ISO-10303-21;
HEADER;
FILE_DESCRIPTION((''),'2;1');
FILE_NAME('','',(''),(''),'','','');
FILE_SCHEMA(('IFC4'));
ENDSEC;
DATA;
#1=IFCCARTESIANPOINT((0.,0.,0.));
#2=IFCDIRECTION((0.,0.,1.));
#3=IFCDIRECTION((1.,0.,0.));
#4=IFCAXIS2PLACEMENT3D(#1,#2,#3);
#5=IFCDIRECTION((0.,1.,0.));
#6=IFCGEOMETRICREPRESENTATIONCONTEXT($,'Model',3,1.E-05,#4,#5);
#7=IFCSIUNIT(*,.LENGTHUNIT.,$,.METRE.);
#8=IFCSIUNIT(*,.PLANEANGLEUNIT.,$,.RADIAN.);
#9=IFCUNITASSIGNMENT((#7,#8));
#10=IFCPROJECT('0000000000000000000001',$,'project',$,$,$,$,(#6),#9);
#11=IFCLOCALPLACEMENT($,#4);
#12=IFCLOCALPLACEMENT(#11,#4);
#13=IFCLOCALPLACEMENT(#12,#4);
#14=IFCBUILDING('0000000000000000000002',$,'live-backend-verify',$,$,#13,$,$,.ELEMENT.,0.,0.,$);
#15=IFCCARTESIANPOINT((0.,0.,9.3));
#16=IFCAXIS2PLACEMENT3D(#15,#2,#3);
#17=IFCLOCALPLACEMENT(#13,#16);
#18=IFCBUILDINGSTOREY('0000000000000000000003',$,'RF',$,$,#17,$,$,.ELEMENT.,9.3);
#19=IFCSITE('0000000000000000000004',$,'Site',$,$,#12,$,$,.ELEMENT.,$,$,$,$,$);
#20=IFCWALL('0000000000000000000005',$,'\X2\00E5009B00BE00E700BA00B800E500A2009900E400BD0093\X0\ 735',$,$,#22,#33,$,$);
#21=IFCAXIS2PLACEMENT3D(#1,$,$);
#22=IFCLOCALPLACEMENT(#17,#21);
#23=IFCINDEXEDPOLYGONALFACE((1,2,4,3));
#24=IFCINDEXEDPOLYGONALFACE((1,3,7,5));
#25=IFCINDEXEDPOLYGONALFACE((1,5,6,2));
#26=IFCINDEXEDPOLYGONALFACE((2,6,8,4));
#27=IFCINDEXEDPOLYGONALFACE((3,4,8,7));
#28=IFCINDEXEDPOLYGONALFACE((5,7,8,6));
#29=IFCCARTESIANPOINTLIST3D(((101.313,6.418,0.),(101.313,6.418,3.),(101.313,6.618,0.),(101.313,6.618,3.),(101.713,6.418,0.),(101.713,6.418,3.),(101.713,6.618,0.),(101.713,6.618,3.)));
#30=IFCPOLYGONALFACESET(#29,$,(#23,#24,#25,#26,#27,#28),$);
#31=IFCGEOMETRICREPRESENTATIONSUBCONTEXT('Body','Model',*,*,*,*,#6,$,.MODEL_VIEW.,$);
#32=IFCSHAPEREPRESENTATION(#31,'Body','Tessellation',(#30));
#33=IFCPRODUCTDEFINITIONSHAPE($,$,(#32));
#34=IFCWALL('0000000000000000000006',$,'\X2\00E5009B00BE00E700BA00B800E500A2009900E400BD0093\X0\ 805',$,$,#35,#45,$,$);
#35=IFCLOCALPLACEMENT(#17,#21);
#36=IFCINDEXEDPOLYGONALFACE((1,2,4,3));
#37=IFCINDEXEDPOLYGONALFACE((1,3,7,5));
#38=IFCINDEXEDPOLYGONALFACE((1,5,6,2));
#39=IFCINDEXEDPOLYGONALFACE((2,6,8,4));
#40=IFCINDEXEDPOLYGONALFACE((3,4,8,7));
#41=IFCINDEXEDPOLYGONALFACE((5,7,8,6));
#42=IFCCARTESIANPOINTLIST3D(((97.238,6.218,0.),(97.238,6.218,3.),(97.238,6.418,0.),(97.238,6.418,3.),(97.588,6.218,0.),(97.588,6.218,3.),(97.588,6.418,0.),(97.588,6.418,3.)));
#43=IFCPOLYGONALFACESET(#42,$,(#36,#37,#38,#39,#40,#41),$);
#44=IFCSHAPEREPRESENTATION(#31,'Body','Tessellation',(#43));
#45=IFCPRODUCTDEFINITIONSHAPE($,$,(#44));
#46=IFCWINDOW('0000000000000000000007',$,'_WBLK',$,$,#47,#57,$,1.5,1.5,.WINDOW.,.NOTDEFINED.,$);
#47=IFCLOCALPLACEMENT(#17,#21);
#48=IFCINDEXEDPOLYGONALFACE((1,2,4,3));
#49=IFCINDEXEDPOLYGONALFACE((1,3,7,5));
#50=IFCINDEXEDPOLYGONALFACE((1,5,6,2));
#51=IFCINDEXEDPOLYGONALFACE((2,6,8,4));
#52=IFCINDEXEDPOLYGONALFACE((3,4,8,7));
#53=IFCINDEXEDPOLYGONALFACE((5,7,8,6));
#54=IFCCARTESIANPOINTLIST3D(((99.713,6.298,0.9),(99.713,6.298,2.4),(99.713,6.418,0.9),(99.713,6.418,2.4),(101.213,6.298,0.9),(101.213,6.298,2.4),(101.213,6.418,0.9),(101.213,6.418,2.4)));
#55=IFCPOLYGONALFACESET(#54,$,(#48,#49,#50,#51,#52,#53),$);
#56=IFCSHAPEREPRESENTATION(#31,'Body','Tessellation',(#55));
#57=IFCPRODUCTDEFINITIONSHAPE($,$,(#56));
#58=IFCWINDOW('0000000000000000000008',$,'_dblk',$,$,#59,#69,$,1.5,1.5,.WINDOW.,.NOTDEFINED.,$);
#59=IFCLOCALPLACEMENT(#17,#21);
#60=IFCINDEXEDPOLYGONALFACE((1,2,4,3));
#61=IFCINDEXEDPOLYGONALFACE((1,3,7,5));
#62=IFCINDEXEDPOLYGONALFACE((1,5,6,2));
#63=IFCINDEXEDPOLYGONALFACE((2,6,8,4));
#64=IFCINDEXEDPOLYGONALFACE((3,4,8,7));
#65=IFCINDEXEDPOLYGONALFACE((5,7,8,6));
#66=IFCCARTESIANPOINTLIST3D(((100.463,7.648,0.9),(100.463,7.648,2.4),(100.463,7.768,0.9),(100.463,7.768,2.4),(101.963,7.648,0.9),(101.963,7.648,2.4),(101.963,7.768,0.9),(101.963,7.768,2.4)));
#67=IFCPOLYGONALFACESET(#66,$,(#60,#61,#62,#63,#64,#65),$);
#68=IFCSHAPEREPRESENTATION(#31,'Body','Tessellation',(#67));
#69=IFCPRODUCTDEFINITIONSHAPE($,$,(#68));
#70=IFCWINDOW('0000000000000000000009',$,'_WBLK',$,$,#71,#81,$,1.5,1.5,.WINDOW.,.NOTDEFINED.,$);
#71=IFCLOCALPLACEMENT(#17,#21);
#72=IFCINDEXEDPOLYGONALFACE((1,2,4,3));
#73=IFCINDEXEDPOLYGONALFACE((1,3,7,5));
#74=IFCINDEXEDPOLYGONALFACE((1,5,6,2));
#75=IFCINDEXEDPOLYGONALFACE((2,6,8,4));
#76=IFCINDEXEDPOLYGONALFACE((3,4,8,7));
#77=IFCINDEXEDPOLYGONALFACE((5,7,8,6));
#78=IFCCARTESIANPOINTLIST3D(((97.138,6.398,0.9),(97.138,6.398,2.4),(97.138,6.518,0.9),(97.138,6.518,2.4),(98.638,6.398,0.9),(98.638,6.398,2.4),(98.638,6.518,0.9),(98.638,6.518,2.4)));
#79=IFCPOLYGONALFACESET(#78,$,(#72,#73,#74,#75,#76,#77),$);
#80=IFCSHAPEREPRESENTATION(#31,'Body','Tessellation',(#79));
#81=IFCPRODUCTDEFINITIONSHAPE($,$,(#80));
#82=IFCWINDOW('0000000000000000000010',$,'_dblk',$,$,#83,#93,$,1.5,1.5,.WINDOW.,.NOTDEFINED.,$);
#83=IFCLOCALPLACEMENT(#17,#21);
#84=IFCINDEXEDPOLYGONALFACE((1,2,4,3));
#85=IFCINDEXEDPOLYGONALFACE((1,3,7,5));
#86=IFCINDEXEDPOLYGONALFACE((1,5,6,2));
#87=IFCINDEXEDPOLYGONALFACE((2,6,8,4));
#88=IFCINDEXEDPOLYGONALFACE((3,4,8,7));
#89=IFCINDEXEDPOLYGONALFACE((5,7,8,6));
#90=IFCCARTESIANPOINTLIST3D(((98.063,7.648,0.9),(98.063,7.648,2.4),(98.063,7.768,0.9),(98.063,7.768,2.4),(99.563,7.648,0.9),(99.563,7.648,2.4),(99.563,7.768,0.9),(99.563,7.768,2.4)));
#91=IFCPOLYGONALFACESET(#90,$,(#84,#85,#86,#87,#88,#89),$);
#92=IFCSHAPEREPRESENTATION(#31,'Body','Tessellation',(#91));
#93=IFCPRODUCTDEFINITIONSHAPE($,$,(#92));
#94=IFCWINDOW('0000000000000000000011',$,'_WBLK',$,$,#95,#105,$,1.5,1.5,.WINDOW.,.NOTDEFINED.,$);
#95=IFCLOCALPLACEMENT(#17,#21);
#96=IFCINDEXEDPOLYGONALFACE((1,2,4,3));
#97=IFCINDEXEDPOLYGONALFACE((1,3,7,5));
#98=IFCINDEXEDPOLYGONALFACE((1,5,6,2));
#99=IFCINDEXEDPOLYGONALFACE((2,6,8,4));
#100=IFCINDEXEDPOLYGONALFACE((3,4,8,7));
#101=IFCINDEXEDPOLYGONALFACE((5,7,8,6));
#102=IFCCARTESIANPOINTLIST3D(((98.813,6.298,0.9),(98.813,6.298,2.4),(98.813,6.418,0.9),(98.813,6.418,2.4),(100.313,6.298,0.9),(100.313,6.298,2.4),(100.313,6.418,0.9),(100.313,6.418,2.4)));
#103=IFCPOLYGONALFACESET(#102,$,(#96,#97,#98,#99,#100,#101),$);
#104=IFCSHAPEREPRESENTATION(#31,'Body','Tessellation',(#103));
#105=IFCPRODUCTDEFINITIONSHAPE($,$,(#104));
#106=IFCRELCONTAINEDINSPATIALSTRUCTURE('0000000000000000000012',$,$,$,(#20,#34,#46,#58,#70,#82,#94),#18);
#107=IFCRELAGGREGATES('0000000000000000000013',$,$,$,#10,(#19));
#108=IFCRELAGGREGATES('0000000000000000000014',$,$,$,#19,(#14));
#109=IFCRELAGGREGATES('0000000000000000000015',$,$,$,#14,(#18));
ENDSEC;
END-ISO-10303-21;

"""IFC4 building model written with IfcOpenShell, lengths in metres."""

from ifc_helpers import new_model, si_unit, direction, frame, frame_2d, origin_with_axes, place, context, subcontext, project, spatial, rectangle, extrude, element, save


model = new_model("IFC4")

# Units and contexts
model_context = context("Model", 3, precision=1e-05, world=origin_with_axes(), true_north=direction((0.0, 1.0, 0.0)))
body_context = subcontext(model_context, "Body", "Model", "MODEL_VIEW")
ifc_project = project(units=[si_unit("LENGTHUNIT", "METRE"), si_unit("PLANEANGLEUNIT", "RADIAN")], contexts=[model_context])

# Site, building, storey
placement = place(None, origin_with_axes())
site_placement = place(placement, origin_with_axes())
site = spatial("IfcSite", under=ifc_project, at=site_placement, Name="Site", CompositionType="ELEMENT")
building_placement = place(site_placement, origin_with_axes())
building = spatial("IfcBuilding", under=site, at=building_placement, Name="live-backend-verify", CompositionType="ELEMENT", ElevationOfRefHeight=0.0, ElevationOfTerrain=0.0)
storey_placement = place(building_placement, frame((0.0, 0.0, 9.3), z_axis=(0.0, 0.0, 1.0), x_axis=(1.0, 0.0, 0.0)))
storey = spatial("IfcBuildingStorey", under=building, at=storey_placement, Name="RF", CompositionType="ELEMENT", Elevation=9.3)

# Walls
wall_1_placement = place(storey_placement, frame((101.513, 6.518, 0.0), z_axis=(0.0, 0.0, 1.0), x_axis=(1.0, 0.0, 0.0)))
element("IfcWall", 1, at=wall_1_placement, inside=storey, Name="å\u009b¾çº¸å¢\u0099ä½\u0093 735", context=body_context, shape_type="SweptSolid", body=[
    extrude(rectangle(XDim=0.4, YDim=0.2, at=frame_2d((0.0, 0.0), x_axis=(1.0, 0.0, 0.0))), frame((0.0, 0.0, 0.0), z_axis=(0.0, 0.0, 1.0)), (0.0, 0.0, 1.0), 3.0),
])
for number, where, z_axis, x_axis, name in (
    (2, (97.413, 6.318, 0.0), (0.0, 0.0, 1.0), (1.0, 0.0, 0.0), "å\u009b¾çº¸å¢\u0099ä½\u0093 805"),
):
    element("IfcWall", number, at=place(storey_placement, frame(where, z_axis=z_axis, x_axis=x_axis)), inside=storey, Name=name, context=body_context, shape_type="SweptSolid", body=[
        extrude(rectangle(XDim=0.35, YDim=0.2, at=frame_2d((0.0, 0.0), x_axis=(1.0, 0.0, 0.0))), frame((0.0, 0.0, 0.0), z_axis=(0.0, 0.0, 1.0)), (0.0, 0.0, 1.0), 3.0),
    ])

# Windows
for number, where, z_axis, x_axis, name in (
    (3, (100.463, 6.358, 0.9), (0.0, 0.0, 1.0), (1.0, 0.0, 0.0), "_WBLK"),
    (4, (101.213, 7.708, 0.9), (0.0, 0.0, 1.0), (1.0, 0.0, 0.0), "_dblk"),
    (5, (97.888, 6.458, 0.9), (0.0, 0.0, 1.0), (1.0, 0.0, 0.0), "_WBLK"),
    (6, (98.813, 7.708, 0.9), (0.0, 0.0, 1.0), (1.0, 0.0, 0.0), "_dblk"),
    (7, (99.563, 6.358, 0.9), (0.0, 0.0, 1.0), (1.0, 0.0, 0.0), "_WBLK"),
):
    element("IfcWindow", number, at=place(storey_placement, frame(where, z_axis=z_axis, x_axis=x_axis)), inside=storey, Name=name, OverallHeight=1.5, OverallWidth=1.5, PartitioningType="NOTDEFINED", PredefinedType="WINDOW", context=body_context, shape_type="SweptSolid", body=[
        extrude(rectangle(XDim=1.5, YDim=0.12, at=frame_2d((0.0, 0.0), x_axis=(1.0, 0.0, 0.0))), frame((0.0, 0.0, 0.0), z_axis=(0.0, 0.0, 1.0)), (0.0, 0.0, 1.0), 1.5),
    ])

save(model, "model.ifc")
